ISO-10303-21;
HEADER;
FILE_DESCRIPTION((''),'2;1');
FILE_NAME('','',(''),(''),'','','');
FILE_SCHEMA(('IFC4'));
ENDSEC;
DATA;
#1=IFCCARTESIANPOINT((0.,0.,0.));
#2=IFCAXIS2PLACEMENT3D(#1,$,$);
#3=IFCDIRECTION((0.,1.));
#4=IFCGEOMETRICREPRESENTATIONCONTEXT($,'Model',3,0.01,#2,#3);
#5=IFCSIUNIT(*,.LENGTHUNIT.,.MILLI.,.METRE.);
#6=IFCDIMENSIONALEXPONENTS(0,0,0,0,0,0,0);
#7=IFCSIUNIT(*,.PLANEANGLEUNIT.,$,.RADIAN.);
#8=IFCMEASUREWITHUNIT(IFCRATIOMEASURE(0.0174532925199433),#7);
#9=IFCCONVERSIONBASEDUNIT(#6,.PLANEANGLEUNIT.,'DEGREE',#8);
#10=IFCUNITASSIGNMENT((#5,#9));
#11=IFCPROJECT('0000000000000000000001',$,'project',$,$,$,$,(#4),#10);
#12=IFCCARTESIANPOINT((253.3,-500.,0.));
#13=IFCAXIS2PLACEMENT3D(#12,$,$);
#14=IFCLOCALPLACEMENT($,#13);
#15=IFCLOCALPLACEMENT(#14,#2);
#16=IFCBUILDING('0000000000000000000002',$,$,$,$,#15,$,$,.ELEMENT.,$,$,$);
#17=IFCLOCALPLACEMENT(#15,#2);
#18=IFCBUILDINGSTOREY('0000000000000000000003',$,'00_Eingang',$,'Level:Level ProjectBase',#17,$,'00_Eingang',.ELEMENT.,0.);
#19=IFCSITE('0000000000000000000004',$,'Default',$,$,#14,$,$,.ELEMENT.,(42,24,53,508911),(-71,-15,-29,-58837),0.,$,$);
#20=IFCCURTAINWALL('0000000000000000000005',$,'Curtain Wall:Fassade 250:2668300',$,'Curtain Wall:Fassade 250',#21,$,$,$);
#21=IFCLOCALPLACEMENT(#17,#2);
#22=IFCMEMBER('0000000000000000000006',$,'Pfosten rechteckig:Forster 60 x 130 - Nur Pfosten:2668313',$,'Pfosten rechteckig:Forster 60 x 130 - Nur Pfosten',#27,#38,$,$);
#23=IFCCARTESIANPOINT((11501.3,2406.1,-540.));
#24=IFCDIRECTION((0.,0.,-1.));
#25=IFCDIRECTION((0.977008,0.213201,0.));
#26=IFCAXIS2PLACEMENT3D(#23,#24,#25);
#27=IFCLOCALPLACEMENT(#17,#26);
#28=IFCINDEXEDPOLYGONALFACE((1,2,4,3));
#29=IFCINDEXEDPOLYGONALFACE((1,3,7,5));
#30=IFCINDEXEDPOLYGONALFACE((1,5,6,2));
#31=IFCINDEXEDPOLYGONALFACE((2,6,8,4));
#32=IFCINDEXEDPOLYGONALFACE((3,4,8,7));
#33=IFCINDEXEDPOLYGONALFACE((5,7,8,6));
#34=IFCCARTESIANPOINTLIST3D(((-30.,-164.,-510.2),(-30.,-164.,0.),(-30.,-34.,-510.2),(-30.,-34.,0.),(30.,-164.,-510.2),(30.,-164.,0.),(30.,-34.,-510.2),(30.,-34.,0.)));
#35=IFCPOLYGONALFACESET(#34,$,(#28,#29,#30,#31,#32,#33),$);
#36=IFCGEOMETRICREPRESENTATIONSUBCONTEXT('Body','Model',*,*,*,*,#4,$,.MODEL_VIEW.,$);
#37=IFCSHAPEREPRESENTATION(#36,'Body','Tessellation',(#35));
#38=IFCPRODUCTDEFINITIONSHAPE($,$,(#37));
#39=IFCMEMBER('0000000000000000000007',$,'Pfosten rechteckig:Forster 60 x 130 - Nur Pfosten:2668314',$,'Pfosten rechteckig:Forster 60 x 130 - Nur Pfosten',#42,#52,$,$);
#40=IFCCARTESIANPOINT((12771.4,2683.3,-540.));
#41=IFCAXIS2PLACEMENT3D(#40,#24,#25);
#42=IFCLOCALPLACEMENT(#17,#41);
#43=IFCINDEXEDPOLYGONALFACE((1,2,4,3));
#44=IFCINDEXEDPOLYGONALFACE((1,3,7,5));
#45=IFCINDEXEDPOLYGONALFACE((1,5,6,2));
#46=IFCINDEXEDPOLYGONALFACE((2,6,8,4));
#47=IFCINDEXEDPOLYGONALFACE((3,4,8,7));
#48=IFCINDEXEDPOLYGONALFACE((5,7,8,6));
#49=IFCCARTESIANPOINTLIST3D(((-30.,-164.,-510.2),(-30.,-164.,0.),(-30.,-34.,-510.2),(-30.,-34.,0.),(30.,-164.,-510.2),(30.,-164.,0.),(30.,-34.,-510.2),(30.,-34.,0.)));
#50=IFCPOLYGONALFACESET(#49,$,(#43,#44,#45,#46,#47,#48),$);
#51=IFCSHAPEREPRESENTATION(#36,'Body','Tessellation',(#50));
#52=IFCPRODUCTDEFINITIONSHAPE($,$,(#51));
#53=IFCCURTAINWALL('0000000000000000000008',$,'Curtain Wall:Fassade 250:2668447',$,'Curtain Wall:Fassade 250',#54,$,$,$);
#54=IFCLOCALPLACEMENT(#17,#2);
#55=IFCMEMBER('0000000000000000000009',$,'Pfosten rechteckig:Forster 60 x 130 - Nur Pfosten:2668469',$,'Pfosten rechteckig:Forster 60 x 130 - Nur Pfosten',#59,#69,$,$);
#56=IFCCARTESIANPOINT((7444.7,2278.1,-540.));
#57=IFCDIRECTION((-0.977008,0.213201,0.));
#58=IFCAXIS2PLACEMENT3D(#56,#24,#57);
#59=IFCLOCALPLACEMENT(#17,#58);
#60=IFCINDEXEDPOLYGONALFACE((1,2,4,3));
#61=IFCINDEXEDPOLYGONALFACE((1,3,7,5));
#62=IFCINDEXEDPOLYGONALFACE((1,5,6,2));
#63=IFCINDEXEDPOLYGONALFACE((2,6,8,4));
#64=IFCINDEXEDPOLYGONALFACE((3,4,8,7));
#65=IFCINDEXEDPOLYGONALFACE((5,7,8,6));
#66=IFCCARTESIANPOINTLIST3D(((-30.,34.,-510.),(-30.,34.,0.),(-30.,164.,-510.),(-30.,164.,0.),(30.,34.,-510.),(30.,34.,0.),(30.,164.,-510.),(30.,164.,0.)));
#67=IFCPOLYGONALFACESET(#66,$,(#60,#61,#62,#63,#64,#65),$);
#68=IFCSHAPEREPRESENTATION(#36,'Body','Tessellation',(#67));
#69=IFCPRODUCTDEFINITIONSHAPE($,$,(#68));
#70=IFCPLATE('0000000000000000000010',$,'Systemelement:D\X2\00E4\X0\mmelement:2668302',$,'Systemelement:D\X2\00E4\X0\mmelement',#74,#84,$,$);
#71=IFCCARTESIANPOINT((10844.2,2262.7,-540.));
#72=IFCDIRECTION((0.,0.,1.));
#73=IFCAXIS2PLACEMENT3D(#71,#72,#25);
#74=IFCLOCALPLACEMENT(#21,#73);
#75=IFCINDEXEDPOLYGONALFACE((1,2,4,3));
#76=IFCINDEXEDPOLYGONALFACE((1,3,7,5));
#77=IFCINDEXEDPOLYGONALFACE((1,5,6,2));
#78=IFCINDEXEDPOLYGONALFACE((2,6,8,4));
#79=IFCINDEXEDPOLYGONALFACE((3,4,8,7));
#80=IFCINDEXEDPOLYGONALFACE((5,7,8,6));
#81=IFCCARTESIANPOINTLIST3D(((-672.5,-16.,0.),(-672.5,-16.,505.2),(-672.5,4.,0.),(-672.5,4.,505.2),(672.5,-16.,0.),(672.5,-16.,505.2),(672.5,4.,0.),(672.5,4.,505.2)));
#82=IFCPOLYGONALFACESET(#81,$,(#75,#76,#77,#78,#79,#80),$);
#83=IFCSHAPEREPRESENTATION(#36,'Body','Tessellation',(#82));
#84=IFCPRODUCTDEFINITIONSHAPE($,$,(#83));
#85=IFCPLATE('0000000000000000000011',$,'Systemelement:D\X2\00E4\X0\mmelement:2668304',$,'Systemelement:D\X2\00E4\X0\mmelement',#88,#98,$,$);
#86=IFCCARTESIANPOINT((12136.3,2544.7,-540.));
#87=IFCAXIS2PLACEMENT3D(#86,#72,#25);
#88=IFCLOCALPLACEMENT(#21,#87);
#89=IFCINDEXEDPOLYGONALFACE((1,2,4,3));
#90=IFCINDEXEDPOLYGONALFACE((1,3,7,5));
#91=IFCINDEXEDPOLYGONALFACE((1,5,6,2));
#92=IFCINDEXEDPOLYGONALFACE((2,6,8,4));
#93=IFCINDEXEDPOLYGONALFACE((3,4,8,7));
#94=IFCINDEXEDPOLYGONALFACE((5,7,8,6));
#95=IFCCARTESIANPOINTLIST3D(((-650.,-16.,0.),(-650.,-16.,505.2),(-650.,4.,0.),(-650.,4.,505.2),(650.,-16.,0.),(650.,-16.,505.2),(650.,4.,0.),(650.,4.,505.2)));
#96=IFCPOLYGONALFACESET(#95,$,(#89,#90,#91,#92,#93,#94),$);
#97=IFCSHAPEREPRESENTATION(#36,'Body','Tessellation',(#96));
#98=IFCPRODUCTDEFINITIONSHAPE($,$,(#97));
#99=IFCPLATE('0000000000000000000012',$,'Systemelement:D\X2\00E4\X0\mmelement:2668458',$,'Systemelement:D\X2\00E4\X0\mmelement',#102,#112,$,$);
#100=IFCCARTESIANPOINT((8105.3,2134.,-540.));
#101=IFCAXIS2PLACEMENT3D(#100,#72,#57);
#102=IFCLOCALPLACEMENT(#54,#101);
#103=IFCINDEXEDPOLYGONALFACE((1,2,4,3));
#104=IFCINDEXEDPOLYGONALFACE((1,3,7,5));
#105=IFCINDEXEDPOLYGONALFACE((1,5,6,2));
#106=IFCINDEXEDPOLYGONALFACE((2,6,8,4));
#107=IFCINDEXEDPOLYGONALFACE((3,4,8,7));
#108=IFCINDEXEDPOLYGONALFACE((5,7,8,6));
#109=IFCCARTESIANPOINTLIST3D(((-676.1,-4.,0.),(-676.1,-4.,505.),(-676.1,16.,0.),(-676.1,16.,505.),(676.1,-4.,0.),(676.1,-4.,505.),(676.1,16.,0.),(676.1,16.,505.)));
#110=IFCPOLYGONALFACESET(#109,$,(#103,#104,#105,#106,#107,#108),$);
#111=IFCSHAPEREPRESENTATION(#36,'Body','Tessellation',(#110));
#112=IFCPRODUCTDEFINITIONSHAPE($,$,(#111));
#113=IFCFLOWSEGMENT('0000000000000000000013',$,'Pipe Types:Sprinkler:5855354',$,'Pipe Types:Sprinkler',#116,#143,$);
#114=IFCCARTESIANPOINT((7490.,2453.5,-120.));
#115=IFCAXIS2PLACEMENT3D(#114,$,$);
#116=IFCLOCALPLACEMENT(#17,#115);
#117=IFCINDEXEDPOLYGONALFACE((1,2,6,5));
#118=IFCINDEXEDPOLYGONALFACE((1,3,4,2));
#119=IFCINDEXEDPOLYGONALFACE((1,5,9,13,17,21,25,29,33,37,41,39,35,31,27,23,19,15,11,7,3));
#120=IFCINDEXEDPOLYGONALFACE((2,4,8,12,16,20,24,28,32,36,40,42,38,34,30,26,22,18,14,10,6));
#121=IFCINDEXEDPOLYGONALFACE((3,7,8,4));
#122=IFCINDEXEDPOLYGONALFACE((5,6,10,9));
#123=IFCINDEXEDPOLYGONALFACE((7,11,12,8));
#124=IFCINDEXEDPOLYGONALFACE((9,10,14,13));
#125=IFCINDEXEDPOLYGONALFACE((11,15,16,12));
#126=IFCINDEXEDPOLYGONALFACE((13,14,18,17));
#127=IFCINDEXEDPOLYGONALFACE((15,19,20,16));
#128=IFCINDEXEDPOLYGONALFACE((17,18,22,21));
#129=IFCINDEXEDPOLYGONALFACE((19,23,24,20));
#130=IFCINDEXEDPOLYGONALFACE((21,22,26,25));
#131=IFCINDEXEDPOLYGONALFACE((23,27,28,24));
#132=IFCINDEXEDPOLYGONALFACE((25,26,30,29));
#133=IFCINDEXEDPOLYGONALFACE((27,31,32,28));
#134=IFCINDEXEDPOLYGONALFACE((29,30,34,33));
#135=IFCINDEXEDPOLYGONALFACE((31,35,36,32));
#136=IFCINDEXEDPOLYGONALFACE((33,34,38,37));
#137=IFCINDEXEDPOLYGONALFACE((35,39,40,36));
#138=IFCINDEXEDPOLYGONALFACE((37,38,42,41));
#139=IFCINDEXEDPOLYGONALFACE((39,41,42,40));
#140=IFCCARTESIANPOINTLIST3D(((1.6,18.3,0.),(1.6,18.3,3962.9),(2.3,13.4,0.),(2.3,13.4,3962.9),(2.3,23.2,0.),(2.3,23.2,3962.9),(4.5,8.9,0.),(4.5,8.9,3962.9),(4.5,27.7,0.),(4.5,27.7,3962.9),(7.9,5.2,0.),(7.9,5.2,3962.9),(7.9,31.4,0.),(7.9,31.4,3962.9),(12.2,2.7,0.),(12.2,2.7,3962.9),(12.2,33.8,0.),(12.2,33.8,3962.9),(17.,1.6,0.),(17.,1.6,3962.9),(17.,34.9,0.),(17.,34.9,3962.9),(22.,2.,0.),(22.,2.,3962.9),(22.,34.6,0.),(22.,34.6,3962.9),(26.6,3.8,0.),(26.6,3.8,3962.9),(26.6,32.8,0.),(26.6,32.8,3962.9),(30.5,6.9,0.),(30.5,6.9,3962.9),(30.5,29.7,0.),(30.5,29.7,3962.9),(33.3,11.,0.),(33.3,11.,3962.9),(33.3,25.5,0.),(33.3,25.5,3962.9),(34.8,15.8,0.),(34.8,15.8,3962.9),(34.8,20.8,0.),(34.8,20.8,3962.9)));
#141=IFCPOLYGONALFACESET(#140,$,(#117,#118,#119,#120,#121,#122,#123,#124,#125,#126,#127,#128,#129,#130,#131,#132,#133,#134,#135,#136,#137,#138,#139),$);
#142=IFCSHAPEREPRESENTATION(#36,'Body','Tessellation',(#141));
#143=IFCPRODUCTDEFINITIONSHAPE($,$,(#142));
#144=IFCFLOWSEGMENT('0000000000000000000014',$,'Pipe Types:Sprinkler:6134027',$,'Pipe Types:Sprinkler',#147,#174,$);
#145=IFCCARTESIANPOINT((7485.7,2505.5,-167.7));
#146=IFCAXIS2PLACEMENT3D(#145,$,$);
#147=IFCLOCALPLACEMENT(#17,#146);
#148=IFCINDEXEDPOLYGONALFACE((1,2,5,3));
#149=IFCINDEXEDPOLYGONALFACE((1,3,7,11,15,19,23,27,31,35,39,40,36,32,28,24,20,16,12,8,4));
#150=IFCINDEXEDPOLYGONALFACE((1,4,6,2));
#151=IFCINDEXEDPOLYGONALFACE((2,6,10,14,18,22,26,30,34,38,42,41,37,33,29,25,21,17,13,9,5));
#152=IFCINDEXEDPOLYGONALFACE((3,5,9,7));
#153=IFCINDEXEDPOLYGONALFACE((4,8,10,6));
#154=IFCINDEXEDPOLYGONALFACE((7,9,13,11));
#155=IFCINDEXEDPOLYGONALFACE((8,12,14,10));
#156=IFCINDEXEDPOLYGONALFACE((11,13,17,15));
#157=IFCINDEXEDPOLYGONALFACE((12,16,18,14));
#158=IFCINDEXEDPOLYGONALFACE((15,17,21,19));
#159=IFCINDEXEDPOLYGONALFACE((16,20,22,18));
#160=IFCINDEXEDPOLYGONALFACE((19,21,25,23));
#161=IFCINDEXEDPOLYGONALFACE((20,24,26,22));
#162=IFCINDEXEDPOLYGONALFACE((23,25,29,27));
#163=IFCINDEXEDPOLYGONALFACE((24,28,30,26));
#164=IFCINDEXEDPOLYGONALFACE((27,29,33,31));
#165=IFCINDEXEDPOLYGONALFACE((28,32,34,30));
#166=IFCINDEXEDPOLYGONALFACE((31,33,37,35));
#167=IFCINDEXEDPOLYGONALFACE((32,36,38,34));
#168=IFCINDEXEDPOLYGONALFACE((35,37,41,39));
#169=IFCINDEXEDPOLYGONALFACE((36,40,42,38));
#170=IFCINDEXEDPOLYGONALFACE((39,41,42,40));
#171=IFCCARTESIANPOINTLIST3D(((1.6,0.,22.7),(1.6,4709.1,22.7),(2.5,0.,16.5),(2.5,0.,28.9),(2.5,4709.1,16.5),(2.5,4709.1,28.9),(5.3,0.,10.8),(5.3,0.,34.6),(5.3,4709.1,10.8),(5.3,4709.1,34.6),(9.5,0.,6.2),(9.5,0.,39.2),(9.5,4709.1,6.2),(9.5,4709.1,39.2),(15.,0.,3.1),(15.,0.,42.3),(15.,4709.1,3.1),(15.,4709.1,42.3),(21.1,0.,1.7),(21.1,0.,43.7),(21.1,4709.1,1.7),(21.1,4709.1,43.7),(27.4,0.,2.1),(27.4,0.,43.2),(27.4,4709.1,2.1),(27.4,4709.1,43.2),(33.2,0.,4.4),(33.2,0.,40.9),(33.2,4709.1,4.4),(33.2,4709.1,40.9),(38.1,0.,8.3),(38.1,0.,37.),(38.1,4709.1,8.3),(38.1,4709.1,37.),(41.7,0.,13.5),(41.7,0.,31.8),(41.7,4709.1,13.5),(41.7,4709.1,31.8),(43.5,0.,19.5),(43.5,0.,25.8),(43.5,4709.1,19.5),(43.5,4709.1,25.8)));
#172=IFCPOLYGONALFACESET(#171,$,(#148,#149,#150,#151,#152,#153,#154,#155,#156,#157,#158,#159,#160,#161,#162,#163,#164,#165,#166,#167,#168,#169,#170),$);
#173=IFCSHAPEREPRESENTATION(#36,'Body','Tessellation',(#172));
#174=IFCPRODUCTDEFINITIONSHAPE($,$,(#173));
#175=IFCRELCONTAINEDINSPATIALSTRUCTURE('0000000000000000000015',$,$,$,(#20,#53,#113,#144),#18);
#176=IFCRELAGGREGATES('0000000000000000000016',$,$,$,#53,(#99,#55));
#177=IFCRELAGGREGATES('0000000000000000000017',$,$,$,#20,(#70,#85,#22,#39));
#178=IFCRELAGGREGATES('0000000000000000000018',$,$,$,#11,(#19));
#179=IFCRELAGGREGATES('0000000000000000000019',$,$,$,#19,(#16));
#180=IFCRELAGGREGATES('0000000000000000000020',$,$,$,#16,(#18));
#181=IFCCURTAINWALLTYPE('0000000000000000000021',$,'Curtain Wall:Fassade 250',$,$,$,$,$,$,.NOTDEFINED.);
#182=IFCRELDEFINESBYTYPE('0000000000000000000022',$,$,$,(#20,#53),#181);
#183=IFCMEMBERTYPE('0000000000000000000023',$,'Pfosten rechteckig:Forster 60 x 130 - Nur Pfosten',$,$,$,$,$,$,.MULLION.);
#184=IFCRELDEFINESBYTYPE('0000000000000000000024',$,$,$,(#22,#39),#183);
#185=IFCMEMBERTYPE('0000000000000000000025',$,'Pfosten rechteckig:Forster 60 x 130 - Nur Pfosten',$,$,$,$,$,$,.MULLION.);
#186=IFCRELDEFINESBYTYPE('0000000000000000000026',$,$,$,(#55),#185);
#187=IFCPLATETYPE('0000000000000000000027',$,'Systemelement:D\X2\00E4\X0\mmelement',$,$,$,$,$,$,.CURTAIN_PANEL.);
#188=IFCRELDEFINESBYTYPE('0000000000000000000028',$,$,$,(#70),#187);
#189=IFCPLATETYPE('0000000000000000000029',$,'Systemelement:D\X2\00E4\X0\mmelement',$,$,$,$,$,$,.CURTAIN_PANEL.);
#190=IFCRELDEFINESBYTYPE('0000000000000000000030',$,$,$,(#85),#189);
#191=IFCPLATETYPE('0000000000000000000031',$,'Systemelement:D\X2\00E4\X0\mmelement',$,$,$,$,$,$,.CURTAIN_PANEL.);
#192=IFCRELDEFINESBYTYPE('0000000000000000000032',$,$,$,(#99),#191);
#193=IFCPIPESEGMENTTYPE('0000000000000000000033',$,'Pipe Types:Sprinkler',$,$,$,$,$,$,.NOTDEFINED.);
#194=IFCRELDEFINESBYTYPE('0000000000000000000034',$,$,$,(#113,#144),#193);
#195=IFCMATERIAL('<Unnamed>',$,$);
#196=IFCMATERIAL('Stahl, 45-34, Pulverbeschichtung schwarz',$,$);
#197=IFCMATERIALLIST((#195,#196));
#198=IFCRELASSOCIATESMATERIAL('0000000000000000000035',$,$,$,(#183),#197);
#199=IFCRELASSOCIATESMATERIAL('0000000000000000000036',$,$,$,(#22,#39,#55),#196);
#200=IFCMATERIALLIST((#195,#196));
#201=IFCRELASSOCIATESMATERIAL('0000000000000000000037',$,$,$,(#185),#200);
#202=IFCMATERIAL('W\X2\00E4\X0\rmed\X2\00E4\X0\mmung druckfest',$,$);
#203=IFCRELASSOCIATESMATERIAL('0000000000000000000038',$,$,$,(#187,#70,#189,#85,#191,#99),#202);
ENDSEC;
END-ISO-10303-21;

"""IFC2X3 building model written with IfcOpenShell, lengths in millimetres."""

from ifc_helpers import new_model, entity, si_unit, converted_unit, direction, frame, frame_2d, origin, origin_2d_with_axis, place, context, subcontext, project, spatial, rectangle, circle, extrude, source, transform, mapped, material, material_list, type_object, type_shapes, element, aggregate, save


model = new_model("IFC2X3")

# Units and contexts
model_context = context("Model", 3, precision=0.01, world=origin(), true_north=direction((0.0, 1.0)))
body_context = subcontext(model_context, "Body", "Model", "MODEL_VIEW")
ifc_project = project(units=[si_unit("LENGTHUNIT", "METRE", prefix="MILLI"), converted_unit("PLANEANGLEUNIT", "DEGREE", entity("IfcRatioMeasure", 0.0174532925199433), si_unit("PLANEANGLEUNIT", "RADIAN"), dimensions=[0, 0, 0, 0, 0, 0, 0])], contexts=[model_context])

# Site, building, storey
site_placement = place(None, frame((253.3, -500.0, 0.0)))
site = spatial("IfcSite", under=ifc_project, at=site_placement, Name="Default", CompositionType="ELEMENT", RefLatitude=(42, 24, 53, 508911), RefLongitude=(-71, -15, -29, -58837), RefElevation=0.0)
building_placement = place(site_placement, origin())
building = spatial("IfcBuilding", under=site, at=building_placement, CompositionType="ELEMENT")
storey_placement = place(building_placement, origin())
storey = spatial("IfcBuildingStorey", under=building, at=storey_placement, Name="00_Eingang", ObjectType="Level:Level ProjectBase", LongName="00_Eingang", CompositionType="ELEMENT", Elevation=0.0)

# Curtain walls, members
curtain_wall_type = type_object("IfcCurtainWallType", Name="Curtain Wall:Fassade 250", PredefinedType="NOTDEFINED")
curtain_wall_1_placement = place(storey_placement, origin())
curtain_wall_1 = element("IfcCurtainWall", 1, at=curtain_wall_1_placement, inside=storey, type_object=curtain_wall_type, Name="Curtain Wall:Fassade 250:2668300", ObjectType="Curtain Wall:Fassade 250")
ifc_material_1 = material(Name="Stahl, 45-34, Pulverbeschichtung schwarz")
ifc_material_2 = material(Name="<Unnamed>")
ifc_material_list_1 = material_list([ifc_material_2, ifc_material_1])
member_type_1 = type_object("IfcMemberType", Name="Pfosten rechteckig:Forster 60 x 130 - Nur Pfosten", PredefinedType="MULLION", material=ifc_material_list_1)
shared_shape_1 = source(origin(), body_context, "Body", "SweptSolid", [
    extrude(rectangle(XDim=130.0, YDim=60.0, at=origin_2d_with_axis()), frame((0.0, -99.0, -510.2), z_axis=(0.0, 0.0, 1.0), x_axis=(0.0, -1.0, 0.0)), (0.0, 0.0, 1.0), 510.2),
])
type_shapes(member_type_1, [shared_shape_1])
member_1_placement = place(storey_placement, frame((11501.3, 2406.1, -540.0), z_axis=(0.0, 0.0, -1.0), x_axis=(0.977008, 0.213201, 0.0)))
member_1 = element("IfcMember", 2, at=member_1_placement, type_object=member_type_1, material=ifc_material_1, Name="Pfosten rechteckig:Forster 60 x 130 - Nur Pfosten:2668313", ObjectType="Pfosten rechteckig:Forster 60 x 130 - Nur Pfosten", context=body_context, shape_type="MappedRepresentation", body=[
    mapped(shared_shape_1, transform((0.0, 0.0, 0.0), scale=1.0)),
])
member_2_placement = place(storey_placement, frame((12771.4, 2683.3, -540.0), z_axis=(0.0, 0.0, -1.0), x_axis=(0.977008, 0.213201, 0.0)))
member_2 = element("IfcMember", 3, at=member_2_placement, type_object=member_type_1, material=ifc_material_1, Name="Pfosten rechteckig:Forster 60 x 130 - Nur Pfosten:2668314", ObjectType="Pfosten rechteckig:Forster 60 x 130 - Nur Pfosten", context=body_context, shape_type="MappedRepresentation", body=[
    mapped(shared_shape_1, transform((0.0, 0.0, 0.0), scale=1.0)),
])
curtain_wall_2_placement = place(storey_placement, origin())
curtain_wall_2 = element("IfcCurtainWall", 4, at=curtain_wall_2_placement, inside=storey, type_object=curtain_wall_type, Name="Curtain Wall:Fassade 250:2668447", ObjectType="Curtain Wall:Fassade 250")
ifc_material_list_2 = material_list([ifc_material_2, ifc_material_1])
member_type_2 = type_object("IfcMemberType", Name="Pfosten rechteckig:Forster 60 x 130 - Nur Pfosten", PredefinedType="MULLION", material=ifc_material_list_2)
shared_shape_2 = source(origin(), body_context, "Body", "SweptSolid", [
    extrude(rectangle(XDim=130.0, YDim=60.0, at=origin_2d_with_axis()), frame((0.0, 99.0, -510.0), z_axis=(0.0, 0.0, 1.0), x_axis=(0.0, -1.0, 0.0)), (0.0, 0.0, 1.0), 510.0),
])
type_shapes(member_type_2, [shared_shape_2])
member_3_placement = place(storey_placement, frame((7444.7, 2278.1, -540.0), z_axis=(0.0, 0.0, -1.0), x_axis=(-0.977008, 0.213201, 0.0)))
member_3 = element("IfcMember", 5, at=member_3_placement, type_object=member_type_2, material=ifc_material_1, Name="Pfosten rechteckig:Forster 60 x 130 - Nur Pfosten:2668469", ObjectType="Pfosten rechteckig:Forster 60 x 130 - Nur Pfosten", context=body_context, shape_type="MappedRepresentation", body=[
    mapped(shared_shape_2, transform((0.0, 0.0, 0.0), scale=1.0)),
])

# Plates
ifc_material_3 = material(Name="Wärmedämmung druckfest")
plate_type_1 = type_object("IfcPlateType", Name="Systemelement:Dämmelement", PredefinedType="CURTAIN_PANEL", material=ifc_material_3)
shared_shape_3 = source(origin(), body_context, "Body", "SweptSolid", [
    extrude(rectangle(XDim=20.0, YDim=1345.1, at=frame_2d((0.0, 0.0), x_axis=(1.0, 0.0))), frame((0.0, -6.0, 0.0), z_axis=(0.0, 0.0, 1.0), x_axis=(0.0, 1.0, 0.0)), (0.0, 0.0, 1.0), 505.2),
])
type_shapes(plate_type_1, [shared_shape_3])
plate_1_placement = place(curtain_wall_1_placement, frame((10844.2, 2262.7, -540.0), z_axis=(0.0, 0.0, 1.0), x_axis=(0.977008, 0.213201, 0.0)))
plate_1 = element("IfcPlate", 6, at=plate_1_placement, type_object=plate_type_1, material=ifc_material_3, Name="Systemelement:Dämmelement:2668302", ObjectType="Systemelement:Dämmelement", context=body_context, shape_type="MappedRepresentation", body=[
    mapped(shared_shape_3, transform((0.0, 0.0, 0.0), scale=1.0)),
])
plate_type_2 = type_object("IfcPlateType", Name="Systemelement:Dämmelement", PredefinedType="CURTAIN_PANEL", material=ifc_material_3)
shared_shape_4 = source(origin(), body_context, "Body", "SweptSolid", [
    extrude(rectangle(XDim=20.0, YDim=1300.0, at=origin_2d_with_axis()), frame((0.0, -6.0, 0.0), z_axis=(0.0, 0.0, 1.0), x_axis=(0.0, 1.0, 0.0)), (0.0, 0.0, 1.0), 505.2),
])
type_shapes(plate_type_2, [shared_shape_4])
plate_2_placement = place(curtain_wall_1_placement, frame((12136.3, 2544.7, -540.0), z_axis=(0.0, 0.0, 1.0), x_axis=(0.977008, 0.213201, 0.0)))
plate_2 = element("IfcPlate", 7, at=plate_2_placement, type_object=plate_type_2, material=ifc_material_3, Name="Systemelement:Dämmelement:2668304", ObjectType="Systemelement:Dämmelement", context=body_context, shape_type="MappedRepresentation", body=[
    mapped(shared_shape_4, transform((0.0, 0.0, 0.0), scale=1.0)),
])
plate_type_3 = type_object("IfcPlateType", Name="Systemelement:Dämmelement", PredefinedType="CURTAIN_PANEL", material=ifc_material_3)
shared_shape_5 = source(origin(), body_context, "Body", "SweptSolid", [
    extrude(rectangle(XDim=20.0, YDim=1352.2, at=frame_2d((0.0, 0.0), x_axis=(1.0, 0.0))), frame((0.0, 6.0, 0.0), z_axis=(0.0, 0.0, 1.0), x_axis=(0.0, 1.0, 0.0)), (0.0, 0.0, 1.0), 505.0),
])
type_shapes(plate_type_3, [shared_shape_5])
plate_3_placement = place(curtain_wall_2_placement, frame((8105.3, 2134.0, -540.0), z_axis=(0.0, 0.0, 1.0), x_axis=(-0.977008, 0.213201, 0.0)))
plate_3 = element("IfcPlate", 8, at=plate_3_placement, type_object=plate_type_3, material=ifc_material_3, Name="Systemelement:Dämmelement:2668458", ObjectType="Systemelement:Dämmelement", context=body_context, shape_type="MappedRepresentation", body=[
    mapped(shared_shape_5, transform((0.0, 0.0, 0.0), scale=1.0)),
])
aggregate(curtain_wall_2, [plate_3, member_3])

aggregate(curtain_wall_1, [plate_1, plate_2, member_1, member_2])

# Flow segments
pipe_segment_type = type_object("IfcPipeSegmentType", Name="Pipe Types:Sprinkler", PredefinedType="NOTDEFINED")
flow_segment_1_placement = place(storey_placement, frame((7490.0, 2453.5, -120.0)))
element("IfcFlowSegment", 9, at=flow_segment_1_placement, inside=storey, type_object=pipe_segment_type, Name="Pipe Types:Sprinkler:5855354", ObjectType="Pipe Types:Sprinkler", context=body_context, shape_type="SweptSolid", body=[
    extrude(circle(Radius=16.7, at=origin_2d_with_axis()), frame((18.3, 18.3, 0.0), z_axis=(0.0, 0.0, 1.0), x_axis=(-1.0, 0.0, 0.0)), (0.0, 0.0, 1.0), 3962.9),
])
flow_segment_2_placement = place(storey_placement, frame((7485.7, 2505.5, -167.7)))
element("IfcFlowSegment", 10, at=flow_segment_2_placement, inside=storey, type_object=pipe_segment_type, Name="Pipe Types:Sprinkler:6134027", ObjectType="Pipe Types:Sprinkler", context=body_context, shape_type="SweptSolid", body=[
    extrude(circle(Radius=21.1, at=origin_2d_with_axis()), frame((22.7, 0.0, 22.7), z_axis=(0.0, 1.0, 0.0), x_axis=(-1.0, 0.0, 0.0)), (0.0, 0.0, 1.0), 4709.1),
])

save(model, "model.ifc")
